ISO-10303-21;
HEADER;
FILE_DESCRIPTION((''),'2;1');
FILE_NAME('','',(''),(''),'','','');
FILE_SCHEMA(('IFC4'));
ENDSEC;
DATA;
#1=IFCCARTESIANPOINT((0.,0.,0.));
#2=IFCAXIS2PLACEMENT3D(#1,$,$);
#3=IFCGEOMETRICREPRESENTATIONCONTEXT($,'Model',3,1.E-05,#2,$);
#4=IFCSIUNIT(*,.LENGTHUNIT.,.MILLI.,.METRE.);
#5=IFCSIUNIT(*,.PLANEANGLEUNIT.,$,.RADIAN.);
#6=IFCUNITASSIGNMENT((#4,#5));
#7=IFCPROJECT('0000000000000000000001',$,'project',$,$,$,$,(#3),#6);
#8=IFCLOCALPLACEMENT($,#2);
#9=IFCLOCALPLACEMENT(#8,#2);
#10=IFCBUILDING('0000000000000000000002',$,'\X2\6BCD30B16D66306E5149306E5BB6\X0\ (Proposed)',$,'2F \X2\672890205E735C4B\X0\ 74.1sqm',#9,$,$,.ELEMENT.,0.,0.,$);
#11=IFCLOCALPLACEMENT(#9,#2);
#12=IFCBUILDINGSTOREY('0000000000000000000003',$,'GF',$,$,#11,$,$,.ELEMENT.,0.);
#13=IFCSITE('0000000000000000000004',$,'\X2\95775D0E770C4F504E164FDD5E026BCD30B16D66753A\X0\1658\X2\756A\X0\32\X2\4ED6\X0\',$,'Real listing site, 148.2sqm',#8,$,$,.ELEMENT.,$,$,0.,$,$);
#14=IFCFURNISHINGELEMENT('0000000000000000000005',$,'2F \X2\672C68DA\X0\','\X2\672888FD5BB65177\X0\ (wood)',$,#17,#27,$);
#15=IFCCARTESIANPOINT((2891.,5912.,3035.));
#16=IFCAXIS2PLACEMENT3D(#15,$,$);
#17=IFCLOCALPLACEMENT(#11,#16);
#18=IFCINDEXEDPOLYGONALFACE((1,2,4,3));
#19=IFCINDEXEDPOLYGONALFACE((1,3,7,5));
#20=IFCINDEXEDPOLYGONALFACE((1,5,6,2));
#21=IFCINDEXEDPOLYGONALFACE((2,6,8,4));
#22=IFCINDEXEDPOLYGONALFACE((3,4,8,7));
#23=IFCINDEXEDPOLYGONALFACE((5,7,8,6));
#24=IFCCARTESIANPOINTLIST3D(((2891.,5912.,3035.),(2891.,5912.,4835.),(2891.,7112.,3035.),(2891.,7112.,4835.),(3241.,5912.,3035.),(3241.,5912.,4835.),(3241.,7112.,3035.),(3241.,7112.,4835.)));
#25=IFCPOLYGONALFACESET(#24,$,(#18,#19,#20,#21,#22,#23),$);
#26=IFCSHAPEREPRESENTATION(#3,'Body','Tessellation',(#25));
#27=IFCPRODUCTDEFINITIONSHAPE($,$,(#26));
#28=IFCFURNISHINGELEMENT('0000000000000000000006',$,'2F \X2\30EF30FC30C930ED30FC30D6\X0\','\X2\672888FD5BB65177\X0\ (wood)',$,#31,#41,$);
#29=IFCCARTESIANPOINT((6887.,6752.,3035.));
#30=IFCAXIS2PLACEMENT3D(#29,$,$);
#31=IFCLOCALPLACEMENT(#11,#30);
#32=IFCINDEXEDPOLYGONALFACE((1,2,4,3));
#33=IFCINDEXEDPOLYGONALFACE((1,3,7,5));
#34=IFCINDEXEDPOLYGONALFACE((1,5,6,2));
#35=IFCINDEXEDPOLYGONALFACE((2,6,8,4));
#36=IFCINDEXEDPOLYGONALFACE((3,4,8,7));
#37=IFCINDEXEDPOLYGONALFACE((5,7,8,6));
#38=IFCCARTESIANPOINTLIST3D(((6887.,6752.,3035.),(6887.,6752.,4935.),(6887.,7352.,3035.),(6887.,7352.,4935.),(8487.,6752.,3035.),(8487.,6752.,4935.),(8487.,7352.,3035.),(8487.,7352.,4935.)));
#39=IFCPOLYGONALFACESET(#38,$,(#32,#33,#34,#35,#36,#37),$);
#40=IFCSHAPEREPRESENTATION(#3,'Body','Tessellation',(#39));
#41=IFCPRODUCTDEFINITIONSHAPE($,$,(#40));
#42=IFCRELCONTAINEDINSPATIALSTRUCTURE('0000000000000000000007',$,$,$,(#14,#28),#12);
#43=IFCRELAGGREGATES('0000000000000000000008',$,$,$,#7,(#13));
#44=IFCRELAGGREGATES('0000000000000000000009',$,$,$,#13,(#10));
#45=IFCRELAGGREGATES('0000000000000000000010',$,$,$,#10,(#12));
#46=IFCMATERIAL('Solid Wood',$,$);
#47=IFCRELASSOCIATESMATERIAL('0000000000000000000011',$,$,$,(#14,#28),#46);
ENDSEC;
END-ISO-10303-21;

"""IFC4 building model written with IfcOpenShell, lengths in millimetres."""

from ifc_helpers import new_model, si_unit, frame, frame_2d, origin, place, context, project, spatial, rectangle, extrude, material, element, save


model = new_model("IFC4")

# Units and contexts
model_context = context("Model", 3, precision=1e-05, world=origin())
ifc_project = project(units=[si_unit("LENGTHUNIT", "METRE", prefix="MILLI"), si_unit("PLANEANGLEUNIT", "RADIAN")], contexts=[model_context])

# Site, building, storey
site_placement = place(None, origin())
site = spatial("IfcSite", under=ifc_project, at=site_placement, Name="長崎県佐世保市母ケ浦町1658番32他", ObjectType="Real listing site, 148.2sqm", CompositionType="ELEMENT", RefElevation=0.0)
building_placement = place(site_placement, origin())
building = spatial("IfcBuilding", under=site, at=building_placement, Name="母ケ浦の光の家 (Proposed)", ObjectType="2F 木造平屋 74.1sqm", CompositionType="ELEMENT", ElevationOfRefHeight=0.0, ElevationOfTerrain=0.0)
storey_placement = place(building_placement, origin())
storey = spatial("IfcBuildingStorey", under=building, at=storey_placement, Name="GF", CompositionType="ELEMENT", Elevation=0.0)

# Shared definitions
ifc_material_1 = material(Name="Solid Wood")

# Furnishing elements
furnishing_1_placement = place(storey_placement, frame((2891.0, 5912.0, 3035.0)))
element("IfcFurnishingElement", 1, at=furnishing_1_placement, inside=storey, material=ifc_material_1, Name="2F 本棚", Description="木製家具 (wood)", context=model_context, shape_type="SweptSolid", body=[
    extrude(rectangle(XDim=350.0, YDim=1200.0, at=frame_2d((175.0, 600.0))), frame((2891.0, 5912.0, 3035.0)), (0.0, 0.0, 1.0), 1800.0),
])
furnishing_2_placement = place(storey_placement, frame((6887.0, 6752.0, 3035.0)))
element("IfcFurnishingElement", 2, at=furnishing_2_placement, inside=storey, material=ifc_material_1, Name="2F ワードローブ", Description="木製家具 (wood)", context=model_context, shape_type="SweptSolid", body=[
    extrude(rectangle(XDim=1600.0, YDim=600.0, at=frame_2d((800.0, 300.0))), frame((6887.0, 6752.0, 3035.0)), (0.0, 0.0, 1.0), 1900.0),
])

save(model, "model.ifc")
